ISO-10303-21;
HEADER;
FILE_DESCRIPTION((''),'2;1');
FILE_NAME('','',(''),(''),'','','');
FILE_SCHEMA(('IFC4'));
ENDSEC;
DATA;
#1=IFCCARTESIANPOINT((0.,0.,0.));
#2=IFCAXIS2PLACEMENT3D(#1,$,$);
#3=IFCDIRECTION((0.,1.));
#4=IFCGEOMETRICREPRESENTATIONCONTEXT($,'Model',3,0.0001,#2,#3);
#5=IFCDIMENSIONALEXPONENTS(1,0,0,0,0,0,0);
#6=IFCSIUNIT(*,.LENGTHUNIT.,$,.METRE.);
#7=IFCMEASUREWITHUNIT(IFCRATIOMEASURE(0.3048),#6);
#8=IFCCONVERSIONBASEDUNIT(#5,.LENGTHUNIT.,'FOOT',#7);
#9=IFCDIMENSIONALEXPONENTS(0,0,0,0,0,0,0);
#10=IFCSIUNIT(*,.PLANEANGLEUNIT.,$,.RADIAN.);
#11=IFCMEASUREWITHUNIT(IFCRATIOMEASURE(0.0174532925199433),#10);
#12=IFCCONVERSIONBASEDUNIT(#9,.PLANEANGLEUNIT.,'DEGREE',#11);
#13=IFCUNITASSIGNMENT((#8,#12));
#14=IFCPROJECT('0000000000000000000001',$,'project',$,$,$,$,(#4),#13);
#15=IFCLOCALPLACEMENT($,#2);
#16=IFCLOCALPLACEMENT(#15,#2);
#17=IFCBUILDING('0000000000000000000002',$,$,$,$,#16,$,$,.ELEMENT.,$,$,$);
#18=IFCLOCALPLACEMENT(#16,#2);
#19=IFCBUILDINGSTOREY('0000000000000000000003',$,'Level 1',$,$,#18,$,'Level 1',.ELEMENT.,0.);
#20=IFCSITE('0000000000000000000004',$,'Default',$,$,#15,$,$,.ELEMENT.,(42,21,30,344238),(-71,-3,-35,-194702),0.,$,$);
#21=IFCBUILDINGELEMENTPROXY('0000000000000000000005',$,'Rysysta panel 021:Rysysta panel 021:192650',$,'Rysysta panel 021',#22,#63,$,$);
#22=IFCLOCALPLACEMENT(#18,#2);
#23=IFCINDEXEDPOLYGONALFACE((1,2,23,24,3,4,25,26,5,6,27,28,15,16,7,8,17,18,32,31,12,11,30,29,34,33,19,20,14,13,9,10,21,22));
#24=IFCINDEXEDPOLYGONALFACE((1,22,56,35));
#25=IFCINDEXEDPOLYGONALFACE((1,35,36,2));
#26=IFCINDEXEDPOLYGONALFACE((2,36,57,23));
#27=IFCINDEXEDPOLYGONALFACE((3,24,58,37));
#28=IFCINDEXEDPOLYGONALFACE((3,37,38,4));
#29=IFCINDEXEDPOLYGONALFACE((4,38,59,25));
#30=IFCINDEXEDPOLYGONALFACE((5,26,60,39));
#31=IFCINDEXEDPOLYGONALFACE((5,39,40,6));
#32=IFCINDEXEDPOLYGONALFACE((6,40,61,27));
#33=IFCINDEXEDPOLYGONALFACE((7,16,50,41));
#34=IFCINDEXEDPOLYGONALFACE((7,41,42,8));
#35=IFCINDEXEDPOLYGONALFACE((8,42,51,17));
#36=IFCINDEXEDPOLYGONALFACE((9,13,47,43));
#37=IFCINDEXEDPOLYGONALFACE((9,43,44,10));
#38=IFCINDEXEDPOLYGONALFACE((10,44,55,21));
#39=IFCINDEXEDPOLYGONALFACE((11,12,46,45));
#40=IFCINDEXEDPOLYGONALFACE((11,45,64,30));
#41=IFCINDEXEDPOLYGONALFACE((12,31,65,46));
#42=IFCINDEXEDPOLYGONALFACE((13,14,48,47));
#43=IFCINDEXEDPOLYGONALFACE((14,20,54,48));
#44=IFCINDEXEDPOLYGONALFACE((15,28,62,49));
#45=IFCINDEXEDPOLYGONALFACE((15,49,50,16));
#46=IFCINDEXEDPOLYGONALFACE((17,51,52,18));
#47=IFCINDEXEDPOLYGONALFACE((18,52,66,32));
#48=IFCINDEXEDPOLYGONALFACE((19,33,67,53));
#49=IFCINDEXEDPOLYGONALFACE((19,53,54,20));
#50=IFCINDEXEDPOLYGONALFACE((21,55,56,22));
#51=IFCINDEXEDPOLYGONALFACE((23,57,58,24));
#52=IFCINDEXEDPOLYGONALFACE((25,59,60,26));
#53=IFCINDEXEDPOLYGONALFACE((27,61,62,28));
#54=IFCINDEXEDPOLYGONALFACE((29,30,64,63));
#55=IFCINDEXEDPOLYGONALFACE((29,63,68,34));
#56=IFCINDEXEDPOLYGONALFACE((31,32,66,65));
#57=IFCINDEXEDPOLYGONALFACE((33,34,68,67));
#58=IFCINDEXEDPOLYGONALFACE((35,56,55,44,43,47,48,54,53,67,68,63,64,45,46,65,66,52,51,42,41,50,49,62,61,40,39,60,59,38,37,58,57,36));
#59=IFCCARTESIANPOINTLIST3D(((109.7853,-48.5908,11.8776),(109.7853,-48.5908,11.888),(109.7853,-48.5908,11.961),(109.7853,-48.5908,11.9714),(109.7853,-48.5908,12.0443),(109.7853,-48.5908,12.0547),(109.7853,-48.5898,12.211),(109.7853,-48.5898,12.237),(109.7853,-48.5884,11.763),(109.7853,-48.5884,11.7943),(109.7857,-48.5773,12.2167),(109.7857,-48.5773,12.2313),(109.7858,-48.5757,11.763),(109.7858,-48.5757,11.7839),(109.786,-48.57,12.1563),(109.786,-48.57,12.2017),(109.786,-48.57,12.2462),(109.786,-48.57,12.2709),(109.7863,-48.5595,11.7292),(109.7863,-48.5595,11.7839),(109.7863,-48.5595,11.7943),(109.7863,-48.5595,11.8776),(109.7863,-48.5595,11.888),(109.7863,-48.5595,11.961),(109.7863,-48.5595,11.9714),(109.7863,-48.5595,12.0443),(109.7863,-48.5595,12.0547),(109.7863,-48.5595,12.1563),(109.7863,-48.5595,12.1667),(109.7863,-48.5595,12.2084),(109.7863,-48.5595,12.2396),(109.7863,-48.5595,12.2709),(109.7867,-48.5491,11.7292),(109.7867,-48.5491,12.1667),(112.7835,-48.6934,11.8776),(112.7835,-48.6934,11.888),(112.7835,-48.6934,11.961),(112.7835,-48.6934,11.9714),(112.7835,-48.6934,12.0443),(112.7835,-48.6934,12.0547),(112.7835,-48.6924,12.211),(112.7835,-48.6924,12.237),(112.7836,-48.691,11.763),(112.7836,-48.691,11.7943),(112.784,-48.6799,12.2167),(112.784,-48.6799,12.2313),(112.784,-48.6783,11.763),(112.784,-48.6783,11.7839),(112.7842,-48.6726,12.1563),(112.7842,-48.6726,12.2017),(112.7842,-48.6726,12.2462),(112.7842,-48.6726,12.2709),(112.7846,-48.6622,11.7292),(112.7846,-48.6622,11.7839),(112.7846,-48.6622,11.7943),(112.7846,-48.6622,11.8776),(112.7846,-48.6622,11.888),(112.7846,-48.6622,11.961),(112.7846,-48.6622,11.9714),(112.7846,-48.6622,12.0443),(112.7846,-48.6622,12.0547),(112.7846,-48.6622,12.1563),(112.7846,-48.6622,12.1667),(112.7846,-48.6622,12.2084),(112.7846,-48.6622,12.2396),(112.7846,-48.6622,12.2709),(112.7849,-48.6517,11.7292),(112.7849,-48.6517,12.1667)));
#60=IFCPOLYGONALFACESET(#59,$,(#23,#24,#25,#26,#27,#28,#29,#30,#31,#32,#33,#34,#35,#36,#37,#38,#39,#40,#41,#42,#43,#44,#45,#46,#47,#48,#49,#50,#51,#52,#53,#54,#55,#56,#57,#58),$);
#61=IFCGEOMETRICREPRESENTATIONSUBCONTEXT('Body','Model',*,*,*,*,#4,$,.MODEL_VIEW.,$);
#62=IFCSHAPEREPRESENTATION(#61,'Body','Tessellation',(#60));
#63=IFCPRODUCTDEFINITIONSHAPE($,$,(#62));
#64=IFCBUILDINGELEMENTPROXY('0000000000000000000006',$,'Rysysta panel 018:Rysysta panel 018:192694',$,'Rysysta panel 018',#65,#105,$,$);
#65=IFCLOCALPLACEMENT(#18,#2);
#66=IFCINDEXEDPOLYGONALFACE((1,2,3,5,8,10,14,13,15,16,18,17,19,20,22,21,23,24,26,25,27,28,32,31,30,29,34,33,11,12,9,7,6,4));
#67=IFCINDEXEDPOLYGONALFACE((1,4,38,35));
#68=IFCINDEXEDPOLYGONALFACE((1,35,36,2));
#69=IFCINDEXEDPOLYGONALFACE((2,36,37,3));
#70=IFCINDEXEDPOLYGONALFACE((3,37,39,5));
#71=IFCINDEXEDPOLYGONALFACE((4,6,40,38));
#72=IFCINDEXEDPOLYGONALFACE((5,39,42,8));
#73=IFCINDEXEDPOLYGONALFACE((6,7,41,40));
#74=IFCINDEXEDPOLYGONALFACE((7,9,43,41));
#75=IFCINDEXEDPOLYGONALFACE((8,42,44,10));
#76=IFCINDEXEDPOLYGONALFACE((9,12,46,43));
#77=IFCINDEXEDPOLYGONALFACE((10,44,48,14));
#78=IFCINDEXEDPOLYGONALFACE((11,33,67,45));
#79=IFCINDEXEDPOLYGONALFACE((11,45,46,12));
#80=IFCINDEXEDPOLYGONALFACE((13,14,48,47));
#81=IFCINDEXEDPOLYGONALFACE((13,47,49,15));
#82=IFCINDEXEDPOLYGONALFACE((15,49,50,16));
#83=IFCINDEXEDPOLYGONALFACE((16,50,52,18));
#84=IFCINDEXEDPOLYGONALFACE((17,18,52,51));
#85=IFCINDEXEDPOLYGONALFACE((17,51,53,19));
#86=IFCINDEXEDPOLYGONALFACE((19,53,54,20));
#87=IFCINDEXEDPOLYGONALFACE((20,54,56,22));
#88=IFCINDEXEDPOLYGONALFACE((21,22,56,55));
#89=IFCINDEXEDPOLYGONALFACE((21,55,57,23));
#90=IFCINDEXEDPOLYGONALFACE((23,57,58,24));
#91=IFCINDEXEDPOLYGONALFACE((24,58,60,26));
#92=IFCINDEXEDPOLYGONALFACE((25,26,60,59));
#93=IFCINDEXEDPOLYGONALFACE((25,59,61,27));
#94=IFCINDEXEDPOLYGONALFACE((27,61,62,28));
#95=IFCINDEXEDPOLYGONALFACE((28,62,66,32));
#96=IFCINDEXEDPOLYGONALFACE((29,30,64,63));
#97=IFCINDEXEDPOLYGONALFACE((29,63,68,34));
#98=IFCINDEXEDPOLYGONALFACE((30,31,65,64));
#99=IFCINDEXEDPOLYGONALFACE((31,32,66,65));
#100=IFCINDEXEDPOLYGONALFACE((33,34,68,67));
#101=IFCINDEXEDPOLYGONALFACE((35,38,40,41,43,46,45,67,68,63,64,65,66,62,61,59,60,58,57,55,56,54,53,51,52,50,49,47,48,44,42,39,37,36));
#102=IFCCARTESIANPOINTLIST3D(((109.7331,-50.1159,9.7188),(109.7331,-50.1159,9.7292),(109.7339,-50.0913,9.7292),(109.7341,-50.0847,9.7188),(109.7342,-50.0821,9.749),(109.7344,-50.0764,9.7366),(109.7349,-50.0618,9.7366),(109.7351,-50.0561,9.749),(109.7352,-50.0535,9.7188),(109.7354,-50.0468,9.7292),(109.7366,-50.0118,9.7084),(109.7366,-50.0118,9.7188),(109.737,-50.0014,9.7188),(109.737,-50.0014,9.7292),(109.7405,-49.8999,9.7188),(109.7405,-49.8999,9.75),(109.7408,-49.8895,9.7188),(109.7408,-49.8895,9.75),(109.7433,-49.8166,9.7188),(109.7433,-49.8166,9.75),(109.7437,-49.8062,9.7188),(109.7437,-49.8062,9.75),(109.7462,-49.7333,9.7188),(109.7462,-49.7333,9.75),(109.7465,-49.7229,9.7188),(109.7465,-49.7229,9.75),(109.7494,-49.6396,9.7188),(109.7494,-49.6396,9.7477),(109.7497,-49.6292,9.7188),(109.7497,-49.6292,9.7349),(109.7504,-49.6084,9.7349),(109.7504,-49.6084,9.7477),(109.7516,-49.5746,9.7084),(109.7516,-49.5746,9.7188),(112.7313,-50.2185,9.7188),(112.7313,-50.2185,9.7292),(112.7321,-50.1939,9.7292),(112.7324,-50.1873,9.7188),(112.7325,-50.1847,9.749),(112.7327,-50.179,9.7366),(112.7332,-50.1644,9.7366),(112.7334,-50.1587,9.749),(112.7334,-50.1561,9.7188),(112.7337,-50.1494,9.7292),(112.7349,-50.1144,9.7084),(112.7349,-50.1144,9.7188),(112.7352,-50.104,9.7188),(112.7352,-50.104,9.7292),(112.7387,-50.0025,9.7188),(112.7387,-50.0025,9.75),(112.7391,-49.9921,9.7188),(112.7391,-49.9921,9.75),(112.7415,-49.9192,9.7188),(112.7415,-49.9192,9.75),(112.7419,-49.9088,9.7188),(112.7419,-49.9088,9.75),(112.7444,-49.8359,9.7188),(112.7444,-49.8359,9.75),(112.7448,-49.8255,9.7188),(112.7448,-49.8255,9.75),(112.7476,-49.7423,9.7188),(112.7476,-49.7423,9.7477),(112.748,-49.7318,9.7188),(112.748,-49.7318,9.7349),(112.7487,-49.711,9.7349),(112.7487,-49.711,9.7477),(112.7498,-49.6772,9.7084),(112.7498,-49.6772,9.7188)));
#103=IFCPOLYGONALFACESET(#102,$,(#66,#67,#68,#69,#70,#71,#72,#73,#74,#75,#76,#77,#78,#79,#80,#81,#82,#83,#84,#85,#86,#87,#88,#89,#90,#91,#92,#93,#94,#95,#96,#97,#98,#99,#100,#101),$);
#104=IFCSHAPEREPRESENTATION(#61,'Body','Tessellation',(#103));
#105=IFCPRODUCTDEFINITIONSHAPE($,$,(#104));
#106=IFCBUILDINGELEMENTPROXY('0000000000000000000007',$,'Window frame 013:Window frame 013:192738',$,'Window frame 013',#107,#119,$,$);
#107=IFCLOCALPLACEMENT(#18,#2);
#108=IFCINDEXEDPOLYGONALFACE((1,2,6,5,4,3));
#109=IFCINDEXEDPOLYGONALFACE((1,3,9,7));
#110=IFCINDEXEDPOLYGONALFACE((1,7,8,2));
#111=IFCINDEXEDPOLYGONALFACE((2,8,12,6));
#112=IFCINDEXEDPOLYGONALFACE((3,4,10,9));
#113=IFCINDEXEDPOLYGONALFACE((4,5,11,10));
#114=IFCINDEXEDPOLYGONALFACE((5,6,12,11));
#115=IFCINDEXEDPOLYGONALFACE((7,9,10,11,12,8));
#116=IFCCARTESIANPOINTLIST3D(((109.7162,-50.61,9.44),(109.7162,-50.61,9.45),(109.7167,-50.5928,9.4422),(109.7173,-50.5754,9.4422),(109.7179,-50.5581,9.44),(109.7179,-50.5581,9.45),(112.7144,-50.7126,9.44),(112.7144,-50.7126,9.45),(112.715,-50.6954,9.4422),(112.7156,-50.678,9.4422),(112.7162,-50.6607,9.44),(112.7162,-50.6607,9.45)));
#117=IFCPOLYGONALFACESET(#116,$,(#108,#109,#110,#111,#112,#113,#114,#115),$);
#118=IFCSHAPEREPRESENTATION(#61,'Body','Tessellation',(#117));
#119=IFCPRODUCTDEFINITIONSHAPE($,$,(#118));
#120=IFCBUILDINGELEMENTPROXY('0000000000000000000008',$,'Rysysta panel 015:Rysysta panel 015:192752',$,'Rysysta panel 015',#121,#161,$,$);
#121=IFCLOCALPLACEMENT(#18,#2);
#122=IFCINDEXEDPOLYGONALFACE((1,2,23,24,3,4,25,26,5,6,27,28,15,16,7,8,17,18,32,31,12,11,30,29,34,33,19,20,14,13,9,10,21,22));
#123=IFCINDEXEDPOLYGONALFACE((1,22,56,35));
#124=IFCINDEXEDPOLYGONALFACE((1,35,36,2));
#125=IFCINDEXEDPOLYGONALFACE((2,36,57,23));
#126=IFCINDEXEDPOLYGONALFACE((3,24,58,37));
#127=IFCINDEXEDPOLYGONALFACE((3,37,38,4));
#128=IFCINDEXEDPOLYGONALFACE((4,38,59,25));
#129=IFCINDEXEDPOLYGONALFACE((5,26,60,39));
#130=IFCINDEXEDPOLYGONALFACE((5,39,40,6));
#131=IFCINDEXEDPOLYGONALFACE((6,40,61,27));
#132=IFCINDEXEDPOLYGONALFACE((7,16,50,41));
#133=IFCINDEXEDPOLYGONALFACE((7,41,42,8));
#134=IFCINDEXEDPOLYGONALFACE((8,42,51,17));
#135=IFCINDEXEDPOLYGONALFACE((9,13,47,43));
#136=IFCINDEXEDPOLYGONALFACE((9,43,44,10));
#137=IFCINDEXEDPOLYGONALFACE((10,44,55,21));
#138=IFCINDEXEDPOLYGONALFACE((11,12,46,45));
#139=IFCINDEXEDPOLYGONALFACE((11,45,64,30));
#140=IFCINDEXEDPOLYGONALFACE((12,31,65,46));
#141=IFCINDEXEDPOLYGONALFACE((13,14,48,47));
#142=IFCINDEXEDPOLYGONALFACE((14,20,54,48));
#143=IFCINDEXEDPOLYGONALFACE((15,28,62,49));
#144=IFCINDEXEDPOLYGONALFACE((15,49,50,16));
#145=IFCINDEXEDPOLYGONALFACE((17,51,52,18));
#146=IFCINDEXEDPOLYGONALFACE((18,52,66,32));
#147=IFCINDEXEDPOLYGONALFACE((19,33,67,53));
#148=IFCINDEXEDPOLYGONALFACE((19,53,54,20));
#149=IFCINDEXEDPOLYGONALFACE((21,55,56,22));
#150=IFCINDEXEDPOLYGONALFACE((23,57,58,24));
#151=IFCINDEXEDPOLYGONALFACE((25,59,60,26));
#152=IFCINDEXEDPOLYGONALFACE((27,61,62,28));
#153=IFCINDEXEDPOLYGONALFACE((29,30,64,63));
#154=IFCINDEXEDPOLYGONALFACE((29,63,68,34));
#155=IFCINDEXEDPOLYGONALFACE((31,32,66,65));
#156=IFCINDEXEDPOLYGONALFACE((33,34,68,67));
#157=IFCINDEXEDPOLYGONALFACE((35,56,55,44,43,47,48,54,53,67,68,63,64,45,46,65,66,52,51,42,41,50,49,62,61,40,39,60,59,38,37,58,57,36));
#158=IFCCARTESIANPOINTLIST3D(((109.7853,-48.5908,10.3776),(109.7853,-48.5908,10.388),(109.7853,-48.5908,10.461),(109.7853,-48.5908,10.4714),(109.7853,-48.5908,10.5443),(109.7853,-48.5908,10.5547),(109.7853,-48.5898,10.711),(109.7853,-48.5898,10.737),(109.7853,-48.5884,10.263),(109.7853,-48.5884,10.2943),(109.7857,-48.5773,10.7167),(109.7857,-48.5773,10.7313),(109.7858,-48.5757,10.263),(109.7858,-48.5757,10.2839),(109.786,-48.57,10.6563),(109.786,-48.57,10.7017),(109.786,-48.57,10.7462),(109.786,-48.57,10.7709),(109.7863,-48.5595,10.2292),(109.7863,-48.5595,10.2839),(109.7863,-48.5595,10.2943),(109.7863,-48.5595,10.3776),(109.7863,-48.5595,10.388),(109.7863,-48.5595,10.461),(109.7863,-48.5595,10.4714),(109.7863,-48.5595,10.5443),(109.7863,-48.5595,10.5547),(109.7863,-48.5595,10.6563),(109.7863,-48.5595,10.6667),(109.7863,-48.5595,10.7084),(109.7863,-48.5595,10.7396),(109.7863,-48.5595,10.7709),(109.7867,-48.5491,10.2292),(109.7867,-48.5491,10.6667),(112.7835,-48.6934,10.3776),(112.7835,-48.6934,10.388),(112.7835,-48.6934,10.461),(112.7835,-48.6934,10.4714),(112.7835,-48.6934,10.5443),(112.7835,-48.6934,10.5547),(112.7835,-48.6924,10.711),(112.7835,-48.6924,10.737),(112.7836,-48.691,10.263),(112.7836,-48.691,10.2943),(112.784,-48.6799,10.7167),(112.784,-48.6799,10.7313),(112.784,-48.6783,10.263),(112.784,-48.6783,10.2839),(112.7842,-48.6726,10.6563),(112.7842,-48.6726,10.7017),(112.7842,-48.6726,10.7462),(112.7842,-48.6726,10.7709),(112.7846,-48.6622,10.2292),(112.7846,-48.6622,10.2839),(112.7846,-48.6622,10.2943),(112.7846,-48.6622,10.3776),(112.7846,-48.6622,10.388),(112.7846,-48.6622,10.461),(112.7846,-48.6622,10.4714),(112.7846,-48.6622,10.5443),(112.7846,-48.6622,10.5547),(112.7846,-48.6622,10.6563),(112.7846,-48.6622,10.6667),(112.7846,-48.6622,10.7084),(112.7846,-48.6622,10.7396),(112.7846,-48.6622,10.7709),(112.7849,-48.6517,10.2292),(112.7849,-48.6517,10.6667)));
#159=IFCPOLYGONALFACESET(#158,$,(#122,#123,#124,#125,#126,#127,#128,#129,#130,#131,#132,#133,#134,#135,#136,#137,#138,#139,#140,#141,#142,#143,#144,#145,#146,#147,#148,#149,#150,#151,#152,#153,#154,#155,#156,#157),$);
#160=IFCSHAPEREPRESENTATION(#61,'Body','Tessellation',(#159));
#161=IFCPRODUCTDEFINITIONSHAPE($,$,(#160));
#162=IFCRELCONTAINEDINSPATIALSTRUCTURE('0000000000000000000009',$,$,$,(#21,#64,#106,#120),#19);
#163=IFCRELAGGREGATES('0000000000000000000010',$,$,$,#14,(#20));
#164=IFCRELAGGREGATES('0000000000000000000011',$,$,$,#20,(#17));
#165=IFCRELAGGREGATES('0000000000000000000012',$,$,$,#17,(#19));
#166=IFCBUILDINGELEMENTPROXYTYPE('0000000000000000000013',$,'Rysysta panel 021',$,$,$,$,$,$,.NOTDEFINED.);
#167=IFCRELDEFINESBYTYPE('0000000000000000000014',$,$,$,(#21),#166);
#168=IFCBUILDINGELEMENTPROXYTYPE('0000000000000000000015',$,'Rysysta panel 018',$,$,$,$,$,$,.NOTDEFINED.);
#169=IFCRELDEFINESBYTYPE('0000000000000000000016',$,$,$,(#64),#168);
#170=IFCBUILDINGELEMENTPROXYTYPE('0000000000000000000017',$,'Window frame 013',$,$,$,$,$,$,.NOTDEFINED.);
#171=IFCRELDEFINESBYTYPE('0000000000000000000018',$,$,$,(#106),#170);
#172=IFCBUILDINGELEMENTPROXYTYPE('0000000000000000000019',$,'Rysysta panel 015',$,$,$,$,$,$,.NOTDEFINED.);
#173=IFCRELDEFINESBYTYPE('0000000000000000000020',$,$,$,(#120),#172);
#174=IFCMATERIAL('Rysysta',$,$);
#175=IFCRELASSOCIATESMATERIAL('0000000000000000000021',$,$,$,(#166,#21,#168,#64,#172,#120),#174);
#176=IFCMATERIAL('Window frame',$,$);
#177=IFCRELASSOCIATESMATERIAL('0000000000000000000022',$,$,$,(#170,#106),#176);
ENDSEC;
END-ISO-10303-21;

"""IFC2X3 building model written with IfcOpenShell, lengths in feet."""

from ifc_helpers import new_model, entity, si_unit, converted_unit, direction, frame, frame_2d, origin, place, context, subcontext, project, spatial, polyline, circle_curve, parameter, trimmed, segment, composite_curve, outline, extrude, source, transform, mapped, material, type_object, type_shapes, element, save


model = new_model("IFC2X3")

# Units and contexts
model_context = context("Model", 3, precision=0.0001, world=origin(), true_north=direction((0.0, 1.0)))
body_context = subcontext(model_context, "Body", "Model", "MODEL_VIEW")
ifc_project = project(units=[converted_unit("LENGTHUNIT", "FOOT", entity("IfcRatioMeasure", 0.3048), si_unit("LENGTHUNIT", "METRE"), dimensions=[1, 0, 0, 0, 0, 0, 0]), converted_unit("PLANEANGLEUNIT", "DEGREE", entity("IfcRatioMeasure", 0.0174532925199433), si_unit("PLANEANGLEUNIT", "RADIAN"), dimensions=[0, 0, 0, 0, 0, 0, 0])], contexts=[model_context])

# Site, building, storey
site_placement = place(None, origin())
site = spatial("IfcSite", under=ifc_project, at=site_placement, Name="Default", CompositionType="ELEMENT", RefLatitude=(42, 21, 30, 344238), RefLongitude=(-71, -3, -35, -194702), RefElevation=0.0)
building_placement = place(site_placement, origin())
building = spatial("IfcBuilding", under=site, at=building_placement, CompositionType="ELEMENT")
storey_placement = place(building_placement, origin())
storey = spatial("IfcBuildingStorey", under=building, at=storey_placement, Name="Level 1", LongName="Level 1", CompositionType="ELEMENT", Elevation=0.0)

# Building element proxies
ifc_material_1 = material(Name="Rysysta")
building_element_proxy_type_1 = type_object("IfcBuildingElementProxyType", Name="Rysysta panel 021", PredefinedType="NOTDEFINED", material=ifc_material_1)
shared_shape_1 = source(origin(), body_context, "Body", "SweptSolid", [
    extrude(outline(polyline([(-0.022, 0.1457), (-0.022, -0.2918), (-0.0116, -0.2918), (-0.0116, -0.2371), (0.0045, -0.2371), (0.0045, -0.258), (0.0173, -0.258), (0.0173, -0.2267), (-0.0116, -0.2267), (-0.0116, -0.1434), (0.0196, -0.1434), (0.0196, -0.133), (-0.0116, -0.133), (-0.0116, -0.06), (0.0196, -0.06), (0.0196, -0.0496), (-0.0116, -0.0496), (-0.0116, 0.0233), (0.0196, 0.0233), (0.0196, 0.0337), (-0.0116, 0.0337), (-0.0116, 0.1353), (-0.0012, 0.1353), (-0.0012, 0.1807), (0.0186, 0.1899), (0.0186, 0.216), (-0.0012, 0.2252), (-0.0012, 0.2498), (-0.0116, 0.2498), (-0.0116, 0.2186), (0.0062, 0.2103), (0.0062, 0.1956), (-0.0116, 0.1873), (-0.0116, 0.1457), (-0.022, 0.1457)])), frame((109.7859, -48.5711, 12.021), z_axis=(-0.999415, 0.034202, 0.0), x_axis=(-0.034202, -0.999415, 0.0)), (0.0, 0.0, -1.0), 3.0),
])
type_shapes(building_element_proxy_type_1, [shared_shape_1])
proxy_1_placement = place(storey_placement, origin())
element("IfcBuildingElementProxy", 1, at=proxy_1_placement, inside=storey, type_object=building_element_proxy_type_1, material=ifc_material_1, Name="Rysysta panel 021:Rysysta panel 021:192650", ObjectType="Rysysta panel 021", context=body_context, shape_type="MappedRepresentation", body=[
    mapped(shared_shape_1, transform((0.0, 0.0, 0.0), scale=1.0)),
])
building_element_proxy_type_2 = type_object("IfcBuildingElementProxyType", Name="Rysysta panel 018", PredefinedType="NOTDEFINED", material=ifc_material_1)
shared_shape_2 = source(origin(), body_context, "Body", "SweptSolid", [
    extrude(outline(polyline([(-0.2918, -0.0116), (-0.2918, -0.022), (0.1457, -0.022), (0.1457, -0.0116), (0.1873, -0.0116), (0.1956, 0.0062), (0.2103, 0.0062), (0.2186, -0.0116), (0.2498, -0.0116), (0.2498, -0.0012), (0.2252, -0.0012), (0.216, 0.0186), (0.1899, 0.0186), (0.1807, -0.0012), (0.1353, -0.0012), (0.1353, -0.0116), (0.0337, -0.0116), (0.0337, 0.0196), (0.0233, 0.0196), (0.0233, -0.0116), (-0.0496, -0.0116), (-0.0496, 0.0196), (-0.06, 0.0196), (-0.06, -0.0116), (-0.133, -0.0116), (-0.133, 0.0196), (-0.1434, 0.0196), (-0.1434, -0.0116), (-0.2267, -0.0116), (-0.2267, 0.0173), (-0.258, 0.0173), (-0.258, 0.0045), (-0.2371, 0.0045), (-0.2371, -0.0116), (-0.2918, -0.0116)])), frame((109.7416, -49.8662, 9.7304), z_axis=(-0.999415, 0.034202, 0.0), x_axis=(-0.034202, -0.999415, 0.0)), (0.0, 0.0, -1.0), 3.0),
])
type_shapes(building_element_proxy_type_2, [shared_shape_2])
proxy_2_placement = place(storey_placement, origin())
element("IfcBuildingElementProxy", 2, at=proxy_2_placement, inside=storey, type_object=building_element_proxy_type_2, material=ifc_material_1, Name="Rysysta panel 018:Rysysta panel 018:192694", ObjectType="Rysysta panel 018", context=body_context, shape_type="MappedRepresentation", body=[
    mapped(shared_shape_2, transform((0.0, 0.0, 0.0), scale=1.0)),
])
ifc_material_2 = material(Name="Window frame")
building_element_proxy_type_3 = type_object("IfcBuildingElementProxyType", Name="Window frame 013", PredefinedType="NOTDEFINED", material=ifc_material_2)
shared_shape_3 = source(origin(), body_context, "Body", "SweptSolid", [
    extrude(outline(composite_curve([segment(polyline([(-0.005, -0.026), (0.005, -0.026)]), True, "CONTINUOUS"), segment(polyline([(0.005, -0.026), (0.005, 0.026)]), True, "CONTINUOUS"), segment(polyline([(0.005, 0.026), (-0.005, 0.026)]), True, "CONTINUOUS"), segment(trimmed(circle_curve(frame_2d((-0.1385, 0.0), x_axis=(0.0, 1.0)), 0.136), [parameter(258.997827)], [parameter(281.002173)], True, "PARAMETER"), False, "CONTINUOUS")], self_intersect=False)), frame((109.717, -50.5841, 9.445), z_axis=(0.999415, -0.034202, 0.0), x_axis=(0.0, 0.0, 1.0)), (0.0, 0.0, 1.0), 3.0),
])
type_shapes(building_element_proxy_type_3, [shared_shape_3])
proxy_3_placement = place(storey_placement, origin())
element("IfcBuildingElementProxy", 3, at=proxy_3_placement, inside=storey, type_object=building_element_proxy_type_3, material=ifc_material_2, Name="Window frame 013:Window frame 013:192738", ObjectType="Window frame 013", context=body_context, shape_type="MappedRepresentation", body=[
    mapped(shared_shape_3, transform((0.0, 0.0, 0.0), scale=1.0)),
])
building_element_proxy_type_4 = type_object("IfcBuildingElementProxyType", Name="Rysysta panel 015", PredefinedType="NOTDEFINED", material=ifc_material_1)
shared_shape_4 = source(origin(), body_context, "Body", "SweptSolid", [
    extrude(outline(polyline([(-0.022, 0.1457), (-0.022, -0.2918), (-0.0116, -0.2918), (-0.0116, -0.2371), (0.0045, -0.2371), (0.0045, -0.258), (0.0173, -0.258), (0.0173, -0.2267), (-0.0116, -0.2267), (-0.0116, -0.1434), (0.0196, -0.1434), (0.0196, -0.133), (-0.0116, -0.133), (-0.0116, -0.06), (0.0196, -0.06), (0.0196, -0.0496), (-0.0116, -0.0496), (-0.0116, 0.0233), (0.0196, 0.0233), (0.0196, 0.0337), (-0.0116, 0.0337), (-0.0116, 0.1353), (-0.0012, 0.1353), (-0.0012, 0.1807), (0.0186, 0.1899), (0.0186, 0.216), (-0.0012, 0.2252), (-0.0012, 0.2498), (-0.0116, 0.2498), (-0.0116, 0.2186), (0.0062, 0.2103), (0.0062, 0.1956), (-0.0116, 0.1873), (-0.0116, 0.1457), (-0.022, 0.1457)])), frame((109.7859, -48.5711, 10.521), z_axis=(-0.999415, 0.034202, 0.0), x_axis=(-0.034202, -0.999415, 0.0)), (0.0, 0.0, -1.0), 3.0),
])
type_shapes(building_element_proxy_type_4, [shared_shape_4])
proxy_4_placement = place(storey_placement, origin())
element("IfcBuildingElementProxy", 4, at=proxy_4_placement, inside=storey, type_object=building_element_proxy_type_4, material=ifc_material_1, Name="Rysysta panel 015:Rysysta panel 015:192752", ObjectType="Rysysta panel 015", context=body_context, shape_type="MappedRepresentation", body=[
    mapped(shared_shape_4, transform((0.0, 0.0, 0.0), scale=1.0)),
])

save(model, "model.ifc")
